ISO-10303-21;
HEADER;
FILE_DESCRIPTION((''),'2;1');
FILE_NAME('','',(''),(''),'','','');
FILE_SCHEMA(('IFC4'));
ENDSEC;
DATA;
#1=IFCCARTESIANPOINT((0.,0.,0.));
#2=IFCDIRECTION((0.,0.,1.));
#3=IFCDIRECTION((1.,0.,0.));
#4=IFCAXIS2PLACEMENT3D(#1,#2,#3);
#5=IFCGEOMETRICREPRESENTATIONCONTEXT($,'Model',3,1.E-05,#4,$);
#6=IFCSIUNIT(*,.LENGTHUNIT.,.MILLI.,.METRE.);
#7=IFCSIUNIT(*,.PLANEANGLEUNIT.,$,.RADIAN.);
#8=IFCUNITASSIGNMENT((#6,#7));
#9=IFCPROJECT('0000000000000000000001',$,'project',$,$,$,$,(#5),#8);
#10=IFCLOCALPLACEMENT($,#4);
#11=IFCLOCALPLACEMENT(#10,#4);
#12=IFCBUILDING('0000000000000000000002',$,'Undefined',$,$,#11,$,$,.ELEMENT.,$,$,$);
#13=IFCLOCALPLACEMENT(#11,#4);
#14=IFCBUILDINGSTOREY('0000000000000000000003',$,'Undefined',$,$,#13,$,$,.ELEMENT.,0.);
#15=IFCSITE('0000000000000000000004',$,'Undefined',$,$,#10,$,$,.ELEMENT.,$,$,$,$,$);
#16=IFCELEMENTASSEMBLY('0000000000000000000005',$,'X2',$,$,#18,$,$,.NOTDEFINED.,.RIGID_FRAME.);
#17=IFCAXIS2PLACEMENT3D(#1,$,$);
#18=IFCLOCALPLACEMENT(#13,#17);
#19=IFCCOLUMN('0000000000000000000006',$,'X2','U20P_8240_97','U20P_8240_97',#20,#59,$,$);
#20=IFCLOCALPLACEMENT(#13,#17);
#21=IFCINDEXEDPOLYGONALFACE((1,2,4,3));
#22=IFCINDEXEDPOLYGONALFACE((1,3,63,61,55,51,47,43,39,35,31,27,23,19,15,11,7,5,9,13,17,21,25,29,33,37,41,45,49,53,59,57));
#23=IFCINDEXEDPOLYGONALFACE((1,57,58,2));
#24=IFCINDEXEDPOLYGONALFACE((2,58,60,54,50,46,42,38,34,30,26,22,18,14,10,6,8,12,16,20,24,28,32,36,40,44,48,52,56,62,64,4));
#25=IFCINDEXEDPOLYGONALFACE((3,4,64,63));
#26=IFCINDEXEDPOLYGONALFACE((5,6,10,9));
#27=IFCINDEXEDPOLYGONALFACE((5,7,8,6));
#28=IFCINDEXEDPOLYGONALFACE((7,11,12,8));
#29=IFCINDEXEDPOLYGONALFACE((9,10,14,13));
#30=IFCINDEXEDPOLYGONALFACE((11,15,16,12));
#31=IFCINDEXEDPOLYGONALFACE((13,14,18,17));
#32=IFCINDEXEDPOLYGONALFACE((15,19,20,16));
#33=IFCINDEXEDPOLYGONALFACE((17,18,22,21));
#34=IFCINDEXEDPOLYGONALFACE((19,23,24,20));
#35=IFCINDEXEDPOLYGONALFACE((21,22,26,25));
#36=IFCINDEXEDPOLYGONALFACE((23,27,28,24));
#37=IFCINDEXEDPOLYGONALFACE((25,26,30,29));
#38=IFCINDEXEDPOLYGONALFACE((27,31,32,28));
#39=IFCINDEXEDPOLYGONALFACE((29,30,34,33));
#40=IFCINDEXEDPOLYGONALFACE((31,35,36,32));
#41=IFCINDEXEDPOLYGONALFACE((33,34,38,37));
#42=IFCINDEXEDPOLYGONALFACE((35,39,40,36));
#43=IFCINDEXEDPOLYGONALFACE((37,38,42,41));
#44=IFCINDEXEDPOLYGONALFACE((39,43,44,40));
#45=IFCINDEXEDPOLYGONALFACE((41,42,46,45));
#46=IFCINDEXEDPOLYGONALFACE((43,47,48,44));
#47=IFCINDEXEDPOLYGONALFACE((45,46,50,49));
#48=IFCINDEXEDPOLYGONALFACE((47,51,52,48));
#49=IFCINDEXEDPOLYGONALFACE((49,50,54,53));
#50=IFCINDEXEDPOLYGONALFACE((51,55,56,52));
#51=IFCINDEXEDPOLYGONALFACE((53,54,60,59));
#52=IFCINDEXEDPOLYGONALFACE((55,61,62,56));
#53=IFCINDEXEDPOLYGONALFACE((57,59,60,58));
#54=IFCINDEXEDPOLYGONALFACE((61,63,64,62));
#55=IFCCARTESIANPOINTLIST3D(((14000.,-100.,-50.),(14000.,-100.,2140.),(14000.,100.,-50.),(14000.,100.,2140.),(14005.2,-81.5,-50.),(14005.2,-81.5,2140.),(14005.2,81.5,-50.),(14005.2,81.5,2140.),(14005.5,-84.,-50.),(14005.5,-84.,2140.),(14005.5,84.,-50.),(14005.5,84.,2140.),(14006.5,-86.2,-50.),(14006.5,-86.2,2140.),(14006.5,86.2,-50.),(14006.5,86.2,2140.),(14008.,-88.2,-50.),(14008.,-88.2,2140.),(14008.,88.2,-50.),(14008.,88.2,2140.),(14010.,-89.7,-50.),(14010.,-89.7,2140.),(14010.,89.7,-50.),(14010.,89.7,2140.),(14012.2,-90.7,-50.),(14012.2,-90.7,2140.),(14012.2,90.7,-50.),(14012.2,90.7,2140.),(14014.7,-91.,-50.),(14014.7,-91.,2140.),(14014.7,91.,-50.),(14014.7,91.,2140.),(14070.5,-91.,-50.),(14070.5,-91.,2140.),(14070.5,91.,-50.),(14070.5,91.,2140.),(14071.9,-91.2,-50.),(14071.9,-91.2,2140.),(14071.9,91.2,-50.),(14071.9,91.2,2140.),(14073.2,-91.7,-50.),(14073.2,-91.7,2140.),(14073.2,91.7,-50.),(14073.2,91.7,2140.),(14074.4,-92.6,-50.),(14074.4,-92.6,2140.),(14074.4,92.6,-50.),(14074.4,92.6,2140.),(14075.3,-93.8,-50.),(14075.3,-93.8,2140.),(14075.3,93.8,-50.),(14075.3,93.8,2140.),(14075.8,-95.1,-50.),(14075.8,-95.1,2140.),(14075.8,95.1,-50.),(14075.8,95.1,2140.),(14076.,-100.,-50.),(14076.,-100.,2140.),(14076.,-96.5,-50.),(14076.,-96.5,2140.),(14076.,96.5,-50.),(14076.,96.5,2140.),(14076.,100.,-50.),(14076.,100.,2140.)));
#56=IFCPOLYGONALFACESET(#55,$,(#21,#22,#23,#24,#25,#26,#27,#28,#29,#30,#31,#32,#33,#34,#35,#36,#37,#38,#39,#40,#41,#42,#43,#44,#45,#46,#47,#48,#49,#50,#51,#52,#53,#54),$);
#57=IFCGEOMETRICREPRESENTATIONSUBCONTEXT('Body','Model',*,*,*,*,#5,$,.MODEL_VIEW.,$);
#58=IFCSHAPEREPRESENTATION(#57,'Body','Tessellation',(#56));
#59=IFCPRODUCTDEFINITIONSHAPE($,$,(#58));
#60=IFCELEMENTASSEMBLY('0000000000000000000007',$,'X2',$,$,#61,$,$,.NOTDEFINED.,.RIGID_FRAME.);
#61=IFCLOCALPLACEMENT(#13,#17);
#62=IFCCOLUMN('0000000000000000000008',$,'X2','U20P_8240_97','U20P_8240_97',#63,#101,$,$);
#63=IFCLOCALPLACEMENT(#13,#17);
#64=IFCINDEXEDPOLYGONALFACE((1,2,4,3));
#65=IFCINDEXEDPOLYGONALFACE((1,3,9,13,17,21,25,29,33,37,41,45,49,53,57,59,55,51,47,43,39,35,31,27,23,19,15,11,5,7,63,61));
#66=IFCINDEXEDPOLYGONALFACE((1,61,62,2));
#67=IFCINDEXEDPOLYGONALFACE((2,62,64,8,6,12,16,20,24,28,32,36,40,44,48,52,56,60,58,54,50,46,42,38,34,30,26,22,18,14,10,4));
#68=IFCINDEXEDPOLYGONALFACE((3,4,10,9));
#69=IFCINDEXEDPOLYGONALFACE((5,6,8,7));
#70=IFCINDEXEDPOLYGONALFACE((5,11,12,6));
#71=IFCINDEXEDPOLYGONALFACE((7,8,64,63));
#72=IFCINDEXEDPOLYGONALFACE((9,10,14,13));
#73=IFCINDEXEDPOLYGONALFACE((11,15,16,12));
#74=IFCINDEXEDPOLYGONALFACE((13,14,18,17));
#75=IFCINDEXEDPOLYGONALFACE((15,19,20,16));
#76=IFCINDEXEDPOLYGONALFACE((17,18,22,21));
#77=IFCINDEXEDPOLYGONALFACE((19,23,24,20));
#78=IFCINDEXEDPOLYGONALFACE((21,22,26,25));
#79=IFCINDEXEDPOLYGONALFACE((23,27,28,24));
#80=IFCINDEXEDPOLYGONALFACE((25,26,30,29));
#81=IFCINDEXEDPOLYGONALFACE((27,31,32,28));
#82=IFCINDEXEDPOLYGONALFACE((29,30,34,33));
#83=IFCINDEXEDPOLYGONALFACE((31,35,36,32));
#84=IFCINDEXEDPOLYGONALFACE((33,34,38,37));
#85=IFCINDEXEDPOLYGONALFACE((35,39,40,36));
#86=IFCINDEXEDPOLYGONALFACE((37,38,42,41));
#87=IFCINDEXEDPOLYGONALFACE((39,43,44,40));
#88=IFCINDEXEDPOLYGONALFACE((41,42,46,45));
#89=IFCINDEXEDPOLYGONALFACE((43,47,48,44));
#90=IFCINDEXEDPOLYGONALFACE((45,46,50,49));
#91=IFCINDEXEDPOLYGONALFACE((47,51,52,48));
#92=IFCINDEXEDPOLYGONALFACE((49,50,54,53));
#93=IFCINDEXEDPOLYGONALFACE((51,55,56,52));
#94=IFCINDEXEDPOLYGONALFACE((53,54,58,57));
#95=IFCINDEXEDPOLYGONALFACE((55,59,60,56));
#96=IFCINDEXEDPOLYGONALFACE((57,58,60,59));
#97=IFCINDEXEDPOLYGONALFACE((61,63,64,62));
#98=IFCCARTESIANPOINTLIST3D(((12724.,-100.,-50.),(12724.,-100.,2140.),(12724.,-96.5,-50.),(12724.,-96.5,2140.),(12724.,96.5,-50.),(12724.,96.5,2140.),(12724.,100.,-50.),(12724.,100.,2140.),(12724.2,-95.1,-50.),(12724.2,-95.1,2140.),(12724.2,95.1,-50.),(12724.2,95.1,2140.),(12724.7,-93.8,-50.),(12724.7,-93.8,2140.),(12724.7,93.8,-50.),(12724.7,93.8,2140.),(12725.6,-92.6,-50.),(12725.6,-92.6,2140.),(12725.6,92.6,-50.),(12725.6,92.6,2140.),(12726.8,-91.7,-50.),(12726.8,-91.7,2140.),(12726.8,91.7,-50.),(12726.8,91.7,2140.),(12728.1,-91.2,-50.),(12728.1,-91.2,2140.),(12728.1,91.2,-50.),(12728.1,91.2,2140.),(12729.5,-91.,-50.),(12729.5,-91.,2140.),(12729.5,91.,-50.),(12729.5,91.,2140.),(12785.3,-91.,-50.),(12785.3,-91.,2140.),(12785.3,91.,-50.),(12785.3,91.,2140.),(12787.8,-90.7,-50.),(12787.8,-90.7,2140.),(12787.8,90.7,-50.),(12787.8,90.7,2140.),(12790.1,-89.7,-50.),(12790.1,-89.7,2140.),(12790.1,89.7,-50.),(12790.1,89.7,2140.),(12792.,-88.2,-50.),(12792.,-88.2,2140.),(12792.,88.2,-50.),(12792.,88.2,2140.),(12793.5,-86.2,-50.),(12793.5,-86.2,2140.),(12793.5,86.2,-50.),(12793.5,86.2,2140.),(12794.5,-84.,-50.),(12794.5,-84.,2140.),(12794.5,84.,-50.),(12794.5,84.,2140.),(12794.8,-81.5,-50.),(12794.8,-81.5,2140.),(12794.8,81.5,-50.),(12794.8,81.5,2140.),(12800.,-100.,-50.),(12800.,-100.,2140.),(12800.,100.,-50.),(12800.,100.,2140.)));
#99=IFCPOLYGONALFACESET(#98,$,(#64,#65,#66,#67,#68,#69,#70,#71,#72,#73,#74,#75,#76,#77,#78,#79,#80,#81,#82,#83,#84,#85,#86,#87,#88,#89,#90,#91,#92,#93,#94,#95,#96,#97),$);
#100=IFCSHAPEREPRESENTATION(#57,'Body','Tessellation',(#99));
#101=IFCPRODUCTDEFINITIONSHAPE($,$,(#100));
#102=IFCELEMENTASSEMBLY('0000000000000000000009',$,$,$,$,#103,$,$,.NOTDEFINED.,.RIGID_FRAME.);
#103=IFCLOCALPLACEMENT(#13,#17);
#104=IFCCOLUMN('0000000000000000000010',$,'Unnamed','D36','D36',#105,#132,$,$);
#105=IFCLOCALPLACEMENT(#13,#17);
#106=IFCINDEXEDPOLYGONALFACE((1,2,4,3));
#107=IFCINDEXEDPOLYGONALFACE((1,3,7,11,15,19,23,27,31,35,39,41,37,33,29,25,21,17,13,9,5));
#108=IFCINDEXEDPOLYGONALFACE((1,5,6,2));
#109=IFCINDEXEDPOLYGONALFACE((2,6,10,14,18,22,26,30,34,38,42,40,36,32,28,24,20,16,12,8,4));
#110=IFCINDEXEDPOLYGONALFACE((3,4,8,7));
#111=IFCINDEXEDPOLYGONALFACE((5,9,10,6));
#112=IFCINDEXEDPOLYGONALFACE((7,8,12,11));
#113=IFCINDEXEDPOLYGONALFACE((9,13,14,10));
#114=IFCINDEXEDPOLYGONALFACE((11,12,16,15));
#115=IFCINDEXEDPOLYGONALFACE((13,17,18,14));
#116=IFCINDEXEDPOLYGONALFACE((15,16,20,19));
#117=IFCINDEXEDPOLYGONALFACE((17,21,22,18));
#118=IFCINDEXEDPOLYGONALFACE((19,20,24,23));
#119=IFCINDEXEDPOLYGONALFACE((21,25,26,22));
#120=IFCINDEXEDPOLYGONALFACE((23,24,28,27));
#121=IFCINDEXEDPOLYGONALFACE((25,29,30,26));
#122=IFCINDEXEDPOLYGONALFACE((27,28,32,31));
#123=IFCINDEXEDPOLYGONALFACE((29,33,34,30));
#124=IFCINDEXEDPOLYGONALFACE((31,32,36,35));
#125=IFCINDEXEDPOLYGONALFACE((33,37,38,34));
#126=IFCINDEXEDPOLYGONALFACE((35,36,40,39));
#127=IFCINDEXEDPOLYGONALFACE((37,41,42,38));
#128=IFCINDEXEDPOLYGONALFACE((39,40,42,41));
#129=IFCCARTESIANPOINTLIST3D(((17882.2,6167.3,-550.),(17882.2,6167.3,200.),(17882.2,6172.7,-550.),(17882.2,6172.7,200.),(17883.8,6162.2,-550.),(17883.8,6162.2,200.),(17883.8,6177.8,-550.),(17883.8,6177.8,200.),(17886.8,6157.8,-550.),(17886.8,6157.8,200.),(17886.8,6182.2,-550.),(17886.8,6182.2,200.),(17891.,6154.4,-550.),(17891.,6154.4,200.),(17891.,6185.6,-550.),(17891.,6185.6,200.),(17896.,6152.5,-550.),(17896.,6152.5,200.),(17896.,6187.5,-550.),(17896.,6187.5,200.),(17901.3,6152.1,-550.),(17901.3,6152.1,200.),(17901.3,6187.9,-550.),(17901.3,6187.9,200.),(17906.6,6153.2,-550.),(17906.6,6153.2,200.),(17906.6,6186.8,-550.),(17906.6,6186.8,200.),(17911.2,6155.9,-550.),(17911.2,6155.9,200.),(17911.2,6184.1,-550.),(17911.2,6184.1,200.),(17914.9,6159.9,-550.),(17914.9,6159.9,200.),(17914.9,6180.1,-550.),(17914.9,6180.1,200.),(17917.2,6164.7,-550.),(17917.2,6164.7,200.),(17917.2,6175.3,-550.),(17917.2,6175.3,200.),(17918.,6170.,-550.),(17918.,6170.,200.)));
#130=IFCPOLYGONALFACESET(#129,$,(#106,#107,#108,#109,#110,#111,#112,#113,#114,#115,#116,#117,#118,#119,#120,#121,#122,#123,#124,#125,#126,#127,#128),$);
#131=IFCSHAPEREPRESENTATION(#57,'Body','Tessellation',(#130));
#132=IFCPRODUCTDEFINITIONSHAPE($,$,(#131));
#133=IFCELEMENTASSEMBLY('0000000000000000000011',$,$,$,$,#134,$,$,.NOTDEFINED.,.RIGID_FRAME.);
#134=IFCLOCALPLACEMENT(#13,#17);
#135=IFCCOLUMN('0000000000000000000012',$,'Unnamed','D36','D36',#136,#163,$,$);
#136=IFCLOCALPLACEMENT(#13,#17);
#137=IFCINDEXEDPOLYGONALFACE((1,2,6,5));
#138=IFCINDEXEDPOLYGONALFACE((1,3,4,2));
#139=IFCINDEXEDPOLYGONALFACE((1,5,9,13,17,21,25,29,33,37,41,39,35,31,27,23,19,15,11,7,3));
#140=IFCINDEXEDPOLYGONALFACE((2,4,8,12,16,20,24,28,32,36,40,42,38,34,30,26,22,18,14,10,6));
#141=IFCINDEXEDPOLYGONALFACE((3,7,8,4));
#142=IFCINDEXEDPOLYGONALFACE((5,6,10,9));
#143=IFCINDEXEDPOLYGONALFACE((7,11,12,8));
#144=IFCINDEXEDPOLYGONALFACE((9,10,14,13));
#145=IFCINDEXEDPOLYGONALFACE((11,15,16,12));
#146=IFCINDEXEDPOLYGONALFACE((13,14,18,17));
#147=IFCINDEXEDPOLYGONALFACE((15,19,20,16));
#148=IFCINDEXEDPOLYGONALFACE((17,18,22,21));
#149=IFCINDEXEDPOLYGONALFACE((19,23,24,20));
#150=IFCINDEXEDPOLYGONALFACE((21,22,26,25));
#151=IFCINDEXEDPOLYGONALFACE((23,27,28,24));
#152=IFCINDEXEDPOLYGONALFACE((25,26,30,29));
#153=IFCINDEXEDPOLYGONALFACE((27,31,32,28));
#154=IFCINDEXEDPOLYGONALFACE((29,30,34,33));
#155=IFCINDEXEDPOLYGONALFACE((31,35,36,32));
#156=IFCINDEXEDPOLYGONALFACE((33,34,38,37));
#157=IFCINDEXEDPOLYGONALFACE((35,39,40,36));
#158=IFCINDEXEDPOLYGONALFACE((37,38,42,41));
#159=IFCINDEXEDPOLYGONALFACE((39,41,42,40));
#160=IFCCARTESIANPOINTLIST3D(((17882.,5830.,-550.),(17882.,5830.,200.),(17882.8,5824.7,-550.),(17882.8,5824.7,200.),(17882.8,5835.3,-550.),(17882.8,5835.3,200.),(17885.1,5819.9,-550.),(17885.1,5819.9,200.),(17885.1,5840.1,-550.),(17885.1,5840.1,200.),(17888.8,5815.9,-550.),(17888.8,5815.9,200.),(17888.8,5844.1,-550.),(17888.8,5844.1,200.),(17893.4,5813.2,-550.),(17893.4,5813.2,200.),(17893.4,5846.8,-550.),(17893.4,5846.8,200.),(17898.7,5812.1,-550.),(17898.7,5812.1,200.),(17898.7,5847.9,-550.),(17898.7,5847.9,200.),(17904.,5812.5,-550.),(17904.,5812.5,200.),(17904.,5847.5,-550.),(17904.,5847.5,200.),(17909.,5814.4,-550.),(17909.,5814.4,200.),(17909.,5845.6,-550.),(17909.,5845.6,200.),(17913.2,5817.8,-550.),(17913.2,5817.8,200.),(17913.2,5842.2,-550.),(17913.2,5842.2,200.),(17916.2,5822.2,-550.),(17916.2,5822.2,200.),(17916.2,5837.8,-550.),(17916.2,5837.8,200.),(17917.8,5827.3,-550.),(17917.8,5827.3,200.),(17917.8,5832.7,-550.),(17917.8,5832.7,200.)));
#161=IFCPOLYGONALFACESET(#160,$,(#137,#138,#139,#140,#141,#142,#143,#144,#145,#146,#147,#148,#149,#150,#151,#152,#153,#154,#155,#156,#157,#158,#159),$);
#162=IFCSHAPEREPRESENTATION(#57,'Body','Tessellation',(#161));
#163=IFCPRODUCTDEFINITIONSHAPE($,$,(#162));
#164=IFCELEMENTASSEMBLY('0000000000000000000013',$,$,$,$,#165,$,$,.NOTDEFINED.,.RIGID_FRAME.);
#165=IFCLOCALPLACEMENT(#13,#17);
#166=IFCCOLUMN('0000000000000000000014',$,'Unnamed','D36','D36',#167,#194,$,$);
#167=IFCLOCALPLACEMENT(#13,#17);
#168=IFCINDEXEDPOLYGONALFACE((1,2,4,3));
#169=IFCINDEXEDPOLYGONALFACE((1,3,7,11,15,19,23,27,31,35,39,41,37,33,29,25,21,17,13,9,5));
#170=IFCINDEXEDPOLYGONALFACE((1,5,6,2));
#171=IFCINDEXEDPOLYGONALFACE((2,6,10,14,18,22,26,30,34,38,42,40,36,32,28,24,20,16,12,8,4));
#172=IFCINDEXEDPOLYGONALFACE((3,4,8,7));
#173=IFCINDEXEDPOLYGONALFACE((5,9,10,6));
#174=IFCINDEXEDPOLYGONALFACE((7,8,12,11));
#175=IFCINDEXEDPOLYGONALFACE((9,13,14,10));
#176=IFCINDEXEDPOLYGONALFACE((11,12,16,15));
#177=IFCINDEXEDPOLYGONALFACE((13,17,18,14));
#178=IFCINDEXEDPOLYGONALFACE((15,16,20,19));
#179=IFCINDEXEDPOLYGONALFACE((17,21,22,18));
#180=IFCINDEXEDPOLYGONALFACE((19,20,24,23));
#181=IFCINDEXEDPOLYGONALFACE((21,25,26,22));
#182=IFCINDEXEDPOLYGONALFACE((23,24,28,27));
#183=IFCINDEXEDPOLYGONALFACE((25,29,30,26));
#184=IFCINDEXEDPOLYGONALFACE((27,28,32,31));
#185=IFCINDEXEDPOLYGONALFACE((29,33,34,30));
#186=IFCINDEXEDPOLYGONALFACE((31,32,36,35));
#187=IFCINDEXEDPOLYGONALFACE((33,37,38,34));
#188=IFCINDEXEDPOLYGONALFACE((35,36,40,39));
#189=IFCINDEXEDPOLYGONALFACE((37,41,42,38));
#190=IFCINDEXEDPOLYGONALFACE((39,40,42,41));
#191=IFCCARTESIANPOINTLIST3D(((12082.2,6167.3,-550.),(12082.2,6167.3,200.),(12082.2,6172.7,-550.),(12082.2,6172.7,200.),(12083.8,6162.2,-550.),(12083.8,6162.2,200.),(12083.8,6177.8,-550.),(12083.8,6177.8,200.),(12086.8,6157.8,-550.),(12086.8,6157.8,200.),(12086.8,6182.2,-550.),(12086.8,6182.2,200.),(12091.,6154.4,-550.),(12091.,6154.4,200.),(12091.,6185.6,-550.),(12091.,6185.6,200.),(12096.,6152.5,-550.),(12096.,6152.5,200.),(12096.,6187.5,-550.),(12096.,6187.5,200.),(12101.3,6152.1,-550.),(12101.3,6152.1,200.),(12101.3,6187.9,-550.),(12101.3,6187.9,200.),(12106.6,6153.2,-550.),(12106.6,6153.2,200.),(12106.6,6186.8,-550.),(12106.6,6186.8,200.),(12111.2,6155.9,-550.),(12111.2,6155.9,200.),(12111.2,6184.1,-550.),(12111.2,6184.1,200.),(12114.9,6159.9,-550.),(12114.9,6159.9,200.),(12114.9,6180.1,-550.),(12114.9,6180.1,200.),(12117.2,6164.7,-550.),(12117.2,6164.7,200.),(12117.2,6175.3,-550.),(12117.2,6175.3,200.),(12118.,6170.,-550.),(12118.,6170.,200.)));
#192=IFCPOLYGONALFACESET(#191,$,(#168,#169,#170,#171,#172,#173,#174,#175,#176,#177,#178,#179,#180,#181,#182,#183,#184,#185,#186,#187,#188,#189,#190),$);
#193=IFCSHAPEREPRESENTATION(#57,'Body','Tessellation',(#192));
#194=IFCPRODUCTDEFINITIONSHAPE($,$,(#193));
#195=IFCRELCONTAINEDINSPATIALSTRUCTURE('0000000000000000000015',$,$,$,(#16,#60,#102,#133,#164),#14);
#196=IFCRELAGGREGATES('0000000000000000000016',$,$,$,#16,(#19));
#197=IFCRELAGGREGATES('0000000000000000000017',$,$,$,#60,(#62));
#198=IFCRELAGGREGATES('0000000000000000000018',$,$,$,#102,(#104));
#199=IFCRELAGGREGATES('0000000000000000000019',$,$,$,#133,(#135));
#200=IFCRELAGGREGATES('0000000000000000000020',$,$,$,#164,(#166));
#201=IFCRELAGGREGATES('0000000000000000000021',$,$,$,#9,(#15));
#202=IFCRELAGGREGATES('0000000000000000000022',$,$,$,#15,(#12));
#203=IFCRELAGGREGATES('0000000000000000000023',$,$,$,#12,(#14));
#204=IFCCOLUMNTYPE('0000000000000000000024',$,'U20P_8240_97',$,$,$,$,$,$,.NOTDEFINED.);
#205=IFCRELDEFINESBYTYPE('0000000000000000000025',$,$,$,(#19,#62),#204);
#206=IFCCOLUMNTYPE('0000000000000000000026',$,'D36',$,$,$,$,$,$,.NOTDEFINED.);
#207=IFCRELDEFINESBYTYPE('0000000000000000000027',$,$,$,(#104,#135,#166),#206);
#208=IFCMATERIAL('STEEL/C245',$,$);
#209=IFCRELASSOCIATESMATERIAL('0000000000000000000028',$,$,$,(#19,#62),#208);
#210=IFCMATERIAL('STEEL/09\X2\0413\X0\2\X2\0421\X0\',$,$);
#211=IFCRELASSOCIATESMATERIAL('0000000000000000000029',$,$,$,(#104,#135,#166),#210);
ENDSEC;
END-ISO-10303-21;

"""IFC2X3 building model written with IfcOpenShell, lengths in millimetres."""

from ifc_helpers import new_model, si_unit, frame, origin_with_axes, origin_2d_with_axis, place, context, subcontext, project, spatial, circle, u_section, extrude, material, type_object, element, aggregate, save


model = new_model("IFC2X3")

# Units and contexts
model_context = context("Model", 3, precision=1e-05, world=origin_with_axes())
body_context = subcontext(model_context, "Body", "Model", "MODEL_VIEW")
ifc_project = project(units=[si_unit("LENGTHUNIT", "METRE", prefix="MILLI"), si_unit("PLANEANGLEUNIT", "RADIAN")], contexts=[model_context])

# Site, building, storey
site_placement = place(None, origin_with_axes())
site = spatial("IfcSite", under=ifc_project, at=site_placement, Name="Undefined", CompositionType="ELEMENT")
building_placement = place(site_placement, origin_with_axes())
building = spatial("IfcBuilding", under=site, at=building_placement, Name="Undefined", CompositionType="ELEMENT")
storey_placement = place(building_placement, origin_with_axes())
storey = spatial("IfcBuildingStorey", under=building, at=storey_placement, Name="Undefined", CompositionType="ELEMENT", Elevation=0.0)

# Element assemblies, columns
assembly_1_placement = place(storey_placement, origin_with_axes())
assembly_1 = element("IfcElementAssembly", 1, at=assembly_1_placement, inside=storey, Name="X2", AssemblyPlace="NOTDEFINED", PredefinedType="RIGID_FRAME")
ifc_material_1 = material(Name="STEEL/C245")
column_type_1 = type_object("IfcColumnType", Name="U20P_8240_97", PredefinedType="NOTDEFINED")
column_1_placement = place(assembly_1_placement, frame((14038.0, 0.0, -50.0), z_axis=(0.0, 0.0, 1.0), x_axis=(0.0, -1.0, 0.0)))
column_1 = element("IfcColumn", 2, at=column_1_placement, type_object=column_type_1, material=ifc_material_1, Name="X2", Description="U20P_8240_97", ObjectType="U20P_8240_97", context=body_context, shape_type="SweptSolid", body=[
    extrude(u_section(Depth=200.0, FlangeWidth=76.0, WebThickness=5.2, FlangeThickness=9.0, FilletRadius=9.5, EdgeRadius=5.5, at=origin_2d_with_axis()), frame((0.0, 0.0, 2190.0), z_axis=(0.0, 0.0, -1.0), x_axis=(0.0, 1.0, 0.0)), (0.0, 0.0, 1.0), 2190.0),
])
aggregate(assembly_1, [column_1])
assembly_2_placement = place(storey_placement, origin_with_axes())
assembly_2 = element("IfcElementAssembly", 3, at=assembly_2_placement, inside=storey, Name="X2", AssemblyPlace="NOTDEFINED", PredefinedType="RIGID_FRAME")
column_2_placement = place(assembly_2_placement, frame((12762.0, 0.0, -50.0), z_axis=(0.0, 0.0, 1.0), x_axis=(0.0, 1.0, 0.0)))
column_2 = element("IfcColumn", 4, at=column_2_placement, type_object=column_type_1, material=ifc_material_1, Name="X2", Description="U20P_8240_97", ObjectType="U20P_8240_97", context=body_context, shape_type="SweptSolid", body=[
    extrude(u_section(Depth=200.0, FlangeWidth=76.0, WebThickness=5.2, FlangeThickness=9.0, FilletRadius=9.5, EdgeRadius=5.5, at=origin_2d_with_axis()), frame((0.0, 0.0, 2190.0), z_axis=(0.0, 0.0, -1.0), x_axis=(0.0, 1.0, 0.0)), (0.0, 0.0, 1.0), 2190.0),
])
aggregate(assembly_2, [column_2])
assembly_3_placement = place(storey_placement, origin_with_axes())
assembly_3 = element("IfcElementAssembly", 5, at=assembly_3_placement, inside=storey, AssemblyPlace="NOTDEFINED", PredefinedType="RIGID_FRAME")
ifc_material_2 = material(Name="STEEL/09Г2С")
column_type_2 = type_object("IfcColumnType", Name="D36", PredefinedType="NOTDEFINED")
column_3_placement = place(assembly_3_placement, frame((17900.0, 6170.0, -550.0), z_axis=(0.0, 0.0, 1.0), x_axis=(0.0, -1.0, 0.0)))
column_3 = element("IfcColumn", 6, at=column_3_placement, type_object=column_type_2, material=ifc_material_2, Name="Unnamed", Description="D36", ObjectType="D36", context=body_context, shape_type="SweptSolid", body=[
    extrude(circle(Radius=18.0, at=origin_2d_with_axis()), frame((0.0, 0.0, 750.0), z_axis=(0.0, 0.0, -1.0), x_axis=(0.0, 1.0, 0.0)), (0.0, 0.0, 1.0), 750.0),
])
aggregate(assembly_3, [column_3])
assembly_4_placement = place(storey_placement, origin_with_axes())
assembly_4 = element("IfcElementAssembly", 7, at=assembly_4_placement, inside=storey, AssemblyPlace="NOTDEFINED", PredefinedType="RIGID_FRAME")
column_4_placement = place(assembly_4_placement, frame((17900.0, 5830.0, -550.0), z_axis=(0.0, 0.0, 1.0), x_axis=(0.0, 1.0, 0.0)))
column_4 = element("IfcColumn", 8, at=column_4_placement, type_object=column_type_2, material=ifc_material_2, Name="Unnamed", Description="D36", ObjectType="D36", context=body_context, shape_type="SweptSolid", body=[
    extrude(circle(Radius=18.0, at=origin_2d_with_axis()), frame((0.0, 0.0, 750.0), z_axis=(0.0, 0.0, -1.0), x_axis=(0.0, 1.0, 0.0)), (0.0, 0.0, 1.0), 750.0),
])
aggregate(assembly_4, [column_4])
assembly_5_placement = place(storey_placement, origin_with_axes())
assembly_5 = element("IfcElementAssembly", 9, at=assembly_5_placement, inside=storey, AssemblyPlace="NOTDEFINED", PredefinedType="RIGID_FRAME")
column_5_placement = place(assembly_5_placement, frame((12100.0, 6170.0, -550.0), z_axis=(0.0, 0.0, 1.0), x_axis=(0.0, -1.0, 0.0)))
column_5 = element("IfcColumn", 10, at=column_5_placement, type_object=column_type_2, material=ifc_material_2, Name="Unnamed", Description="D36", ObjectType="D36", context=body_context, shape_type="SweptSolid", body=[
    extrude(circle(Radius=18.0, at=origin_2d_with_axis()), frame((0.0, 0.0, 750.0), z_axis=(0.0, 0.0, -1.0), x_axis=(0.0, 1.0, 0.0)), (0.0, 0.0, 1.0), 750.0),
])
aggregate(assembly_5, [column_5])

save(model, "model.ifc")
